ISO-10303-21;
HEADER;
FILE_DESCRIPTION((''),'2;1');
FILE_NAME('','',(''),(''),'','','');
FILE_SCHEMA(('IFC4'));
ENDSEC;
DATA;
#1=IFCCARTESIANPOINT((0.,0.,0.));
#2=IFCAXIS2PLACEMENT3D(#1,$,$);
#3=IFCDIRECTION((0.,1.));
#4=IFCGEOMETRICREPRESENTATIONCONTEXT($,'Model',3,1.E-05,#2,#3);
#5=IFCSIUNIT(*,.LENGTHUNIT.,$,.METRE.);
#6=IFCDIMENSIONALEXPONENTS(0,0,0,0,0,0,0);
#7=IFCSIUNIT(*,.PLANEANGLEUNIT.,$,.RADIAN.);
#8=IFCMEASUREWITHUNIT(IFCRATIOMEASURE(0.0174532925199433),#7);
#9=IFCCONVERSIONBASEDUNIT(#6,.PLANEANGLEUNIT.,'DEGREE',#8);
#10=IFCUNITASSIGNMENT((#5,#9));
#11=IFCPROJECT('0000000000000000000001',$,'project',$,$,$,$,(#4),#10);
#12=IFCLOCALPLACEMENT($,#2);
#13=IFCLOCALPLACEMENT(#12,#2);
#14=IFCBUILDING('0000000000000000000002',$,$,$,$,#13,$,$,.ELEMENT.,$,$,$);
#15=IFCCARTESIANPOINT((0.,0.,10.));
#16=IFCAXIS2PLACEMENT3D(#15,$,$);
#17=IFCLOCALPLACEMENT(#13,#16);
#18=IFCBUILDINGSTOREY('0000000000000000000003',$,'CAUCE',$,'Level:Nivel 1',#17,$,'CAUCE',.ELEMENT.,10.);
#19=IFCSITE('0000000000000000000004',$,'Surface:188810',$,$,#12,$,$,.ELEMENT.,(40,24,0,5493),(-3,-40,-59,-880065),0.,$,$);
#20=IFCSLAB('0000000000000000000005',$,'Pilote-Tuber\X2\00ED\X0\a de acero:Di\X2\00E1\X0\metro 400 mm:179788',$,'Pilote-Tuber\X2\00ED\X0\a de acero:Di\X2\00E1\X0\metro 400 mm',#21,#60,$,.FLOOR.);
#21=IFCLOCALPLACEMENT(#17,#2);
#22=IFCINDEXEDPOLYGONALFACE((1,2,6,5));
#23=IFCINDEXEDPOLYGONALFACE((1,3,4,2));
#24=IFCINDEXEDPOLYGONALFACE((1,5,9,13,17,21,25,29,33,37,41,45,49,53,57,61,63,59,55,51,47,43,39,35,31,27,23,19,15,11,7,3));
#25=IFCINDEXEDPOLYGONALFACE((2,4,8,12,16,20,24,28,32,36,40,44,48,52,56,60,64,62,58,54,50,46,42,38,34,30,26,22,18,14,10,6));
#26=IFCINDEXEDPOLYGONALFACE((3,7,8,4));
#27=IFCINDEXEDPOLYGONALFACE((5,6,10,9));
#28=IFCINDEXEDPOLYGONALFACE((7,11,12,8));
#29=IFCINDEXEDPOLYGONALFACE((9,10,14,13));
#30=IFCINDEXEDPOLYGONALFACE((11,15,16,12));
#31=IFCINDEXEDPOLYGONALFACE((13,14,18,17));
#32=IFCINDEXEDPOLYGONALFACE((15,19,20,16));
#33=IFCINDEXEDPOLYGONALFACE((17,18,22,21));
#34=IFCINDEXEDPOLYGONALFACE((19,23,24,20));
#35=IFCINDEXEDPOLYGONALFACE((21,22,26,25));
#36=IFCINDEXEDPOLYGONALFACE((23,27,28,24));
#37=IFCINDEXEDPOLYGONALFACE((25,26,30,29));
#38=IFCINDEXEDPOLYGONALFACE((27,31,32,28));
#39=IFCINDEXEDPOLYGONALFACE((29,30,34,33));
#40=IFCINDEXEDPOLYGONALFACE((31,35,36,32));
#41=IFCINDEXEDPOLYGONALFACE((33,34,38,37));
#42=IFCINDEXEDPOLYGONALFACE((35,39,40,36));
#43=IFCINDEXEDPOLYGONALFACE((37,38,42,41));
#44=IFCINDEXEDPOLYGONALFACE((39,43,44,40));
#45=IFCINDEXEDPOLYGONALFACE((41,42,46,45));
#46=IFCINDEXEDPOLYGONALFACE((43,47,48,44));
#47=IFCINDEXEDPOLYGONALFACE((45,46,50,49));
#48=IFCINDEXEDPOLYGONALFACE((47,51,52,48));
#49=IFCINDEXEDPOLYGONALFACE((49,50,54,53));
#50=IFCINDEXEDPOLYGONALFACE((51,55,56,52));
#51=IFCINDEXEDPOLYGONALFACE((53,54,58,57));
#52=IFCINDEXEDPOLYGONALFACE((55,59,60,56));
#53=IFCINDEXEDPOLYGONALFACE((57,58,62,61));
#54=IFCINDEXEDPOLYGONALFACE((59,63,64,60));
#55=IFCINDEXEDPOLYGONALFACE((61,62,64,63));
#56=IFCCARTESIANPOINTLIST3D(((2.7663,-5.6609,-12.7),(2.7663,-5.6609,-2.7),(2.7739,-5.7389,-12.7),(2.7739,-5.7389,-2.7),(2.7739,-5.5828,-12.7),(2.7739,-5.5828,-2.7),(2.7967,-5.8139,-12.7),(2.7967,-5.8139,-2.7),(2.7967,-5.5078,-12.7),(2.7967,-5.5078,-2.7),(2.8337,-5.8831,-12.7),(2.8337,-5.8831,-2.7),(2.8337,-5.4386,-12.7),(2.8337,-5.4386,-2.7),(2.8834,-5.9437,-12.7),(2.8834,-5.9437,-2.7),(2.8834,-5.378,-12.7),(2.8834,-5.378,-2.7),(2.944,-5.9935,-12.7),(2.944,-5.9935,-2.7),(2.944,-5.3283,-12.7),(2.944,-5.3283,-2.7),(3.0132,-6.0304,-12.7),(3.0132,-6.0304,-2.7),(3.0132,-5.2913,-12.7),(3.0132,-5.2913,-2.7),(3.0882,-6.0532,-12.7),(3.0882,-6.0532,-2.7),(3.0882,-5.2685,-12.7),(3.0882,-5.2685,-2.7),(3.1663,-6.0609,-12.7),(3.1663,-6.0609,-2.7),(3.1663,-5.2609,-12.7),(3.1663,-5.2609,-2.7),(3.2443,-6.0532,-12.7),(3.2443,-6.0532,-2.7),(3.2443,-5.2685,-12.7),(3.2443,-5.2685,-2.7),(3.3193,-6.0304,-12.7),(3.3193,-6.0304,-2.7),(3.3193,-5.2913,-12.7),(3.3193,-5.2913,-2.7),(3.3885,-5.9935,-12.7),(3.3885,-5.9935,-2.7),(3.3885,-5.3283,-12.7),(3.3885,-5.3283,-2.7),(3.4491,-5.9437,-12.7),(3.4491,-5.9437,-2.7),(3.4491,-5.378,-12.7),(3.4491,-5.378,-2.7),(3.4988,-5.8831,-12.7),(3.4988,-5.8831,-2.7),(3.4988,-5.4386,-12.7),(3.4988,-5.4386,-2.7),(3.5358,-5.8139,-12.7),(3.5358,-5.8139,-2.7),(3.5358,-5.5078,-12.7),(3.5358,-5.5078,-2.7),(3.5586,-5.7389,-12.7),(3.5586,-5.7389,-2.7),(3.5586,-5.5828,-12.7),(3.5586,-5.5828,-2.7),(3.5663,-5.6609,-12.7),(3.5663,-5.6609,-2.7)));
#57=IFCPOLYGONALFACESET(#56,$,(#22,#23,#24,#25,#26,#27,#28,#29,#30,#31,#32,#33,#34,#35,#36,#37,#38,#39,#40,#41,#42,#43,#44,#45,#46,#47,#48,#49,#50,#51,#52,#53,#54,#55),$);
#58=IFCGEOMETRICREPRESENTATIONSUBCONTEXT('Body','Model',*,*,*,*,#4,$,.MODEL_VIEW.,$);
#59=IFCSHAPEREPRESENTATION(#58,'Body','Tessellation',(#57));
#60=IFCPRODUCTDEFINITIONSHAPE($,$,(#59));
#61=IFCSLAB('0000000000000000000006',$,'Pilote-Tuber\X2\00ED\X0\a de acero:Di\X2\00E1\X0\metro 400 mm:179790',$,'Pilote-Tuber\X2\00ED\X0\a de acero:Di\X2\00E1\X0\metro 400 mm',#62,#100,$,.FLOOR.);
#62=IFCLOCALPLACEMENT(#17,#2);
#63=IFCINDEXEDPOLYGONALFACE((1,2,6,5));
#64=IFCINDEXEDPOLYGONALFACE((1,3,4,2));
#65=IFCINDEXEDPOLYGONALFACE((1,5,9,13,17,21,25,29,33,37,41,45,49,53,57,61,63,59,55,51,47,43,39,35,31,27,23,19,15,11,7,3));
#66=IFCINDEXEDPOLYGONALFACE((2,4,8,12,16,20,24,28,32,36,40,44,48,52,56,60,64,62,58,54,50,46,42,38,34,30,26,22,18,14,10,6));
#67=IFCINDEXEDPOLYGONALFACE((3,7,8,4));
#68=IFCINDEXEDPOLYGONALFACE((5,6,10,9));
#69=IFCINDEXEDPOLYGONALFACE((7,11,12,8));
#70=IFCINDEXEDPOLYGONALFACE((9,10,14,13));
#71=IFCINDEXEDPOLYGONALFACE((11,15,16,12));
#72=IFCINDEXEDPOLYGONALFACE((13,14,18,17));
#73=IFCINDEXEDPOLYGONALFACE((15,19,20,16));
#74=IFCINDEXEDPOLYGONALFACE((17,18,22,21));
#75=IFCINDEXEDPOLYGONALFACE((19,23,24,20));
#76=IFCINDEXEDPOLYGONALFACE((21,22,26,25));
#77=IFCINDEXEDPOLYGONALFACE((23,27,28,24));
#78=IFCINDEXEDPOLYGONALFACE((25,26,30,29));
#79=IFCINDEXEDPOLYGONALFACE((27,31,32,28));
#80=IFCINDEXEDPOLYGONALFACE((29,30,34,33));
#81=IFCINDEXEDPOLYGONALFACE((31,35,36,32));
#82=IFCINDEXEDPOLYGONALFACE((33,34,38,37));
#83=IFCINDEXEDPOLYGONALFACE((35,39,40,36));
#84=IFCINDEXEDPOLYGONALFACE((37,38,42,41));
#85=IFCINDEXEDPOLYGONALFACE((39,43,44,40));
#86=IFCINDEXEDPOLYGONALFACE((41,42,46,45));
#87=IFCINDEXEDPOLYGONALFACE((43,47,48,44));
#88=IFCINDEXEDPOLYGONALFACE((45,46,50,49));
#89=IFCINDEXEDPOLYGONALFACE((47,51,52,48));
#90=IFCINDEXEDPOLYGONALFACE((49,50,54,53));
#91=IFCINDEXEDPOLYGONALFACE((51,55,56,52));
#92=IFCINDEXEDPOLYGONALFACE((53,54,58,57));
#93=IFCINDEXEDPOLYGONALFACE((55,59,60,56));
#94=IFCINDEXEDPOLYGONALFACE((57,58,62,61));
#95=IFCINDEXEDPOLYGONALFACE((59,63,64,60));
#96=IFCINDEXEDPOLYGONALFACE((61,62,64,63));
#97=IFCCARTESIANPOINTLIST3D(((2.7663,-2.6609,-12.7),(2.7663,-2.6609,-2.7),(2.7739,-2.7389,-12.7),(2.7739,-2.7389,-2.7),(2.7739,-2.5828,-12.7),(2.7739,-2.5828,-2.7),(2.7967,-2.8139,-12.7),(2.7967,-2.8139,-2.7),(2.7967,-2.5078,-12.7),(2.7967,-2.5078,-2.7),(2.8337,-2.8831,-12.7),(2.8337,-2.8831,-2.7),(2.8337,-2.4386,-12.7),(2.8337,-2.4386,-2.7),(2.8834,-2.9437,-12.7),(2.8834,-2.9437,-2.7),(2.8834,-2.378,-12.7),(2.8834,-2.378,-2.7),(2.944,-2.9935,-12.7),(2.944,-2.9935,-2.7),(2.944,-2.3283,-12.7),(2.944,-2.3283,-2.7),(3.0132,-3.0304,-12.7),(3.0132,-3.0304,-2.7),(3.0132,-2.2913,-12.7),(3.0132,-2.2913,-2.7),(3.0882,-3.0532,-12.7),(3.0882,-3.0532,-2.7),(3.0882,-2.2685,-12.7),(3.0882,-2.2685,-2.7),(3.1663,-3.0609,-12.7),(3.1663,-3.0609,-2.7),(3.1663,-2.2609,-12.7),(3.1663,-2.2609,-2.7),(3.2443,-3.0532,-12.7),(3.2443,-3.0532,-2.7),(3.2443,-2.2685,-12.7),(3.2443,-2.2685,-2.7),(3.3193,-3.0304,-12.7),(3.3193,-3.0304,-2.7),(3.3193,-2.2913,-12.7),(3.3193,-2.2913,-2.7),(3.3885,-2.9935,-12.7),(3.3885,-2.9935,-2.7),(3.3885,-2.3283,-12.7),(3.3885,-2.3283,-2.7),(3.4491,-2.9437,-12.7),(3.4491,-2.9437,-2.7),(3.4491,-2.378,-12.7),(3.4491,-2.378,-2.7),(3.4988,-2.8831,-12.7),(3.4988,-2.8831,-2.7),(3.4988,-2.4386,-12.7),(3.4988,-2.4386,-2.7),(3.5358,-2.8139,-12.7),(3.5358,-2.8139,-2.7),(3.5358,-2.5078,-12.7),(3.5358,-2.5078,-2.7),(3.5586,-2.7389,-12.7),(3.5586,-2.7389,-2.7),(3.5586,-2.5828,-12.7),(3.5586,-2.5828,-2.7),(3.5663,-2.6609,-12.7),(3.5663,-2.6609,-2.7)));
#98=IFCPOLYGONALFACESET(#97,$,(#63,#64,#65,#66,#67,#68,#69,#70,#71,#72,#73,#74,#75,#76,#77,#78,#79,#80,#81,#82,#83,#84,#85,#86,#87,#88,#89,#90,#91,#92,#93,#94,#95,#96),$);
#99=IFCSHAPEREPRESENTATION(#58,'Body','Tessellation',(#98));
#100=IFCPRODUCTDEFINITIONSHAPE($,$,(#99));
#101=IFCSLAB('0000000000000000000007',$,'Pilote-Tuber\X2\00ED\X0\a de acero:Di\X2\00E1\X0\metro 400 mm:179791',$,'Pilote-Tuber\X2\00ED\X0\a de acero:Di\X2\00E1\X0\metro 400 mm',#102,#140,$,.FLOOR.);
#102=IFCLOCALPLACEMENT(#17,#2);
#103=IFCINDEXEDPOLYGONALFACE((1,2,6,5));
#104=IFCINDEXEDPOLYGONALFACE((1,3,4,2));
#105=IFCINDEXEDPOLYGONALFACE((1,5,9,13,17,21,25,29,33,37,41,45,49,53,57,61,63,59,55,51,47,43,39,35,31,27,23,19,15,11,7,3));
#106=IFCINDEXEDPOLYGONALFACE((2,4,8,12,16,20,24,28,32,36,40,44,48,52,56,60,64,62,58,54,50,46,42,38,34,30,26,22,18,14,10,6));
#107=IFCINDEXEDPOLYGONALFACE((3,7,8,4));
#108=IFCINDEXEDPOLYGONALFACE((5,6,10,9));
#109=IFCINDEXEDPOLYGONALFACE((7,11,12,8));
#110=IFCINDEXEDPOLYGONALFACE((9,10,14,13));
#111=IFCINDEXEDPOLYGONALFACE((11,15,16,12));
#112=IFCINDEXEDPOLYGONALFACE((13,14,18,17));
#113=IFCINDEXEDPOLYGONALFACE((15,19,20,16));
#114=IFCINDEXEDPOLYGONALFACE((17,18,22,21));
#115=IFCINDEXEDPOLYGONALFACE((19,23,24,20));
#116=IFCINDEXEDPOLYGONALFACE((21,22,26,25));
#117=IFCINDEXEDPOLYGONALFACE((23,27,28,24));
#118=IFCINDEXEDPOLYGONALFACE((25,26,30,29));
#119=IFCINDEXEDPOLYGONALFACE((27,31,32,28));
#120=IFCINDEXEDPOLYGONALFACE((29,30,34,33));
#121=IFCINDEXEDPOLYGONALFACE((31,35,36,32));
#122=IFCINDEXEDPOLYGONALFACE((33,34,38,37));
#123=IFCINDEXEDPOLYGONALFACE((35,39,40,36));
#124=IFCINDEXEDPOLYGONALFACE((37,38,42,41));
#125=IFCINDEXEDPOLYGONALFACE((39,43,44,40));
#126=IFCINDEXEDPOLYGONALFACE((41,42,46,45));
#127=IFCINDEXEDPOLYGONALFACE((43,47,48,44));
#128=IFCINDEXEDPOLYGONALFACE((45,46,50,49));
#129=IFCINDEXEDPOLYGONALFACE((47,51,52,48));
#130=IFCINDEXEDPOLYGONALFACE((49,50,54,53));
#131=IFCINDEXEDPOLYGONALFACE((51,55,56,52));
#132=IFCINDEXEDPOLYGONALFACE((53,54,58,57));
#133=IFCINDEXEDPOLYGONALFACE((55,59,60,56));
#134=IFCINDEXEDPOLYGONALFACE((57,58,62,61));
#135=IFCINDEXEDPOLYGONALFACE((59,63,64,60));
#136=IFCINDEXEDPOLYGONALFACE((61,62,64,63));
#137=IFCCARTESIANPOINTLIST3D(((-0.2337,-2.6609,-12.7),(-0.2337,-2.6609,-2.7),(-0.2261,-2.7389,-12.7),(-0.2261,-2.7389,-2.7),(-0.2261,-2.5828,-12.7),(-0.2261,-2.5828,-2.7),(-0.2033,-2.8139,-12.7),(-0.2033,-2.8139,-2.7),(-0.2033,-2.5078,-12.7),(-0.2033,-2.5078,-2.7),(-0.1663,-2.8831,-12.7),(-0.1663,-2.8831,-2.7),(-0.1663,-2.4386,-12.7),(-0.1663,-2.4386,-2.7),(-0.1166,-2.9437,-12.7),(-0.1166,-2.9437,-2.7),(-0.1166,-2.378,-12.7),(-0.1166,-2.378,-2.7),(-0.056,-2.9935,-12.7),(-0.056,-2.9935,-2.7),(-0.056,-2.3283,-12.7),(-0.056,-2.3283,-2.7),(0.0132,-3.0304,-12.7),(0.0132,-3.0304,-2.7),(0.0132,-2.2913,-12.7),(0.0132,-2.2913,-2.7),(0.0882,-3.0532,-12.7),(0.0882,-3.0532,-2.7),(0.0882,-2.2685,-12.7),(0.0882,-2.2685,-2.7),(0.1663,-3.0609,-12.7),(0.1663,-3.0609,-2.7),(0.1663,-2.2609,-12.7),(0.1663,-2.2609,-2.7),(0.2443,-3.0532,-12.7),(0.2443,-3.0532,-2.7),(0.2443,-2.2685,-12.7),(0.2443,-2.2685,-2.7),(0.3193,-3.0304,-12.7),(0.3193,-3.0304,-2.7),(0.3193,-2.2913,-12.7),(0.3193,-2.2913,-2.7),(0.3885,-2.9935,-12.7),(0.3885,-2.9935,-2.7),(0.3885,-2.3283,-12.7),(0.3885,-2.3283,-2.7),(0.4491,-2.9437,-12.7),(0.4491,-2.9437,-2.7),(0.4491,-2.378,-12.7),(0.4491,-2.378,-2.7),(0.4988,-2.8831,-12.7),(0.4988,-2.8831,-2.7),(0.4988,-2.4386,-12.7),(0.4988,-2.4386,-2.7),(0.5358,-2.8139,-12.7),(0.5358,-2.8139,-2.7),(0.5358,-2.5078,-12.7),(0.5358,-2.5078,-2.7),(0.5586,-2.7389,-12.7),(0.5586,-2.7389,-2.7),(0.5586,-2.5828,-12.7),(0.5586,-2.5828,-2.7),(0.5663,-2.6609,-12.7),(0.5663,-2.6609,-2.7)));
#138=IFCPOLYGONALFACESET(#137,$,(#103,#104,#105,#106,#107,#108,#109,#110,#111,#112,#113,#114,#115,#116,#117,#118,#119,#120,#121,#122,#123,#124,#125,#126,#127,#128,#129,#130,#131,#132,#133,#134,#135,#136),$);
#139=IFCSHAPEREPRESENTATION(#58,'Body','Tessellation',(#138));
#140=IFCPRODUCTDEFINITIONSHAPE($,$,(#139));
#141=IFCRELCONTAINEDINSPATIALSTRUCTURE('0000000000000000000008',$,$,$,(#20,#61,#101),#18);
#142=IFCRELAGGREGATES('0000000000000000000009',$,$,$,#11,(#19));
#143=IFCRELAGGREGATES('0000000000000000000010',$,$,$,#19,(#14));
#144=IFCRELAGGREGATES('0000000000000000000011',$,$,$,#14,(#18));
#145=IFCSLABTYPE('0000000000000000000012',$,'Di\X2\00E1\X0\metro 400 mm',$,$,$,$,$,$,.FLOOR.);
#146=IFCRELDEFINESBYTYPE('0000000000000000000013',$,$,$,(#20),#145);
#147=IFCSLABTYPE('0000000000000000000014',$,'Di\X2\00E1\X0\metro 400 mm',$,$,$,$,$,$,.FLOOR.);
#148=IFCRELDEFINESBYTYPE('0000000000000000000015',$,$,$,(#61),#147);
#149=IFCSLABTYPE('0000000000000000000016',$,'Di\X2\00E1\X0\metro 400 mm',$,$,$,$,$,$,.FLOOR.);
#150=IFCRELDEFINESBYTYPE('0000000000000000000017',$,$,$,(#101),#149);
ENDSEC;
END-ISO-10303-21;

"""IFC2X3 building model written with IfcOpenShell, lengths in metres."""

from ifc_helpers import new_model, entity, si_unit, converted_unit, direction, frame, frame_2d, origin, place, context, subcontext, project, spatial, circle, extrude, type_object, element, save


model = new_model("IFC2X3")

# Units and contexts
model_context = context("Model", 3, precision=1e-05, world=origin(), true_north=direction((0.0, 1.0)))
body_context = subcontext(model_context, "Body", "Model", "MODEL_VIEW")
ifc_project = project(units=[si_unit("LENGTHUNIT", "METRE"), converted_unit("PLANEANGLEUNIT", "DEGREE", entity("IfcRatioMeasure", 0.0174532925199433), si_unit("PLANEANGLEUNIT", "RADIAN"), dimensions=[0, 0, 0, 0, 0, 0, 0])], contexts=[model_context])

# Site, building, storey
site_placement = place(None, origin())
site = spatial("IfcSite", under=ifc_project, at=site_placement, Name="Surface:188810", CompositionType="ELEMENT", RefLatitude=(40, 24, 0, 5493), RefLongitude=(-3, -40, -59, -880065), RefElevation=0.0)
building_placement = place(site_placement, origin())
building = spatial("IfcBuilding", under=site, at=building_placement, CompositionType="ELEMENT")
storey_placement = place(building_placement, frame((0.0, 0.0, 10.0)))
storey = spatial("IfcBuildingStorey", under=building, at=storey_placement, Name="CAUCE", ObjectType="Level:Nivel 1", LongName="CAUCE", CompositionType="ELEMENT", Elevation=10.0)

# Slabs
slab_type_1 = type_object("IfcSlabType", Name="Diámetro 400 mm", PredefinedType="FLOOR")
slab_1_placement = place(storey_placement, origin())
element("IfcSlab", 1, at=slab_1_placement, inside=storey, type_object=slab_type_1, Name="Pilote-Tubería de acero:Diámetro 400 mm:179788", ObjectType="Pilote-Tubería de acero:Diámetro 400 mm", PredefinedType="FLOOR", context=body_context, shape_type="SweptSolid", body=[
    extrude(circle(Radius=0.4, at=frame_2d((0.0, 0.0), x_axis=(1.0, 0.0))), frame((3.1663, -5.6609, -12.7)), (0.0, 0.0, 1.0), 10.0),
])
slab_type_2 = type_object("IfcSlabType", Name="Diámetro 400 mm", PredefinedType="FLOOR")
slab_2_placement = place(storey_placement, origin())
element("IfcSlab", 2, at=slab_2_placement, inside=storey, type_object=slab_type_2, Name="Pilote-Tubería de acero:Diámetro 400 mm:179790", ObjectType="Pilote-Tubería de acero:Diámetro 400 mm", PredefinedType="FLOOR", context=body_context, shape_type="SweptSolid", body=[
    extrude(circle(Radius=0.4, at=frame_2d((0.0, 0.0), x_axis=(1.0, 0.0))), frame((3.1663, -2.6609, -12.7)), (0.0, 0.0, 1.0), 10.0),
])
slab_type_3 = type_object("IfcSlabType", Name="Diámetro 400 mm", PredefinedType="FLOOR")
slab_3_placement = place(storey_placement, origin())
element("IfcSlab", 3, at=slab_3_placement, inside=storey, type_object=slab_type_3, Name="Pilote-Tubería de acero:Diámetro 400 mm:179791", ObjectType="Pilote-Tubería de acero:Diámetro 400 mm", PredefinedType="FLOOR", context=body_context, shape_type="SweptSolid", body=[
    extrude(circle(Radius=0.4, at=frame_2d((0.0, 0.0), x_axis=(1.0, 0.0))), frame((0.1663, -2.6609, -12.7)), (0.0, 0.0, 1.0), 10.0),
])

save(model, "model.ifc")
